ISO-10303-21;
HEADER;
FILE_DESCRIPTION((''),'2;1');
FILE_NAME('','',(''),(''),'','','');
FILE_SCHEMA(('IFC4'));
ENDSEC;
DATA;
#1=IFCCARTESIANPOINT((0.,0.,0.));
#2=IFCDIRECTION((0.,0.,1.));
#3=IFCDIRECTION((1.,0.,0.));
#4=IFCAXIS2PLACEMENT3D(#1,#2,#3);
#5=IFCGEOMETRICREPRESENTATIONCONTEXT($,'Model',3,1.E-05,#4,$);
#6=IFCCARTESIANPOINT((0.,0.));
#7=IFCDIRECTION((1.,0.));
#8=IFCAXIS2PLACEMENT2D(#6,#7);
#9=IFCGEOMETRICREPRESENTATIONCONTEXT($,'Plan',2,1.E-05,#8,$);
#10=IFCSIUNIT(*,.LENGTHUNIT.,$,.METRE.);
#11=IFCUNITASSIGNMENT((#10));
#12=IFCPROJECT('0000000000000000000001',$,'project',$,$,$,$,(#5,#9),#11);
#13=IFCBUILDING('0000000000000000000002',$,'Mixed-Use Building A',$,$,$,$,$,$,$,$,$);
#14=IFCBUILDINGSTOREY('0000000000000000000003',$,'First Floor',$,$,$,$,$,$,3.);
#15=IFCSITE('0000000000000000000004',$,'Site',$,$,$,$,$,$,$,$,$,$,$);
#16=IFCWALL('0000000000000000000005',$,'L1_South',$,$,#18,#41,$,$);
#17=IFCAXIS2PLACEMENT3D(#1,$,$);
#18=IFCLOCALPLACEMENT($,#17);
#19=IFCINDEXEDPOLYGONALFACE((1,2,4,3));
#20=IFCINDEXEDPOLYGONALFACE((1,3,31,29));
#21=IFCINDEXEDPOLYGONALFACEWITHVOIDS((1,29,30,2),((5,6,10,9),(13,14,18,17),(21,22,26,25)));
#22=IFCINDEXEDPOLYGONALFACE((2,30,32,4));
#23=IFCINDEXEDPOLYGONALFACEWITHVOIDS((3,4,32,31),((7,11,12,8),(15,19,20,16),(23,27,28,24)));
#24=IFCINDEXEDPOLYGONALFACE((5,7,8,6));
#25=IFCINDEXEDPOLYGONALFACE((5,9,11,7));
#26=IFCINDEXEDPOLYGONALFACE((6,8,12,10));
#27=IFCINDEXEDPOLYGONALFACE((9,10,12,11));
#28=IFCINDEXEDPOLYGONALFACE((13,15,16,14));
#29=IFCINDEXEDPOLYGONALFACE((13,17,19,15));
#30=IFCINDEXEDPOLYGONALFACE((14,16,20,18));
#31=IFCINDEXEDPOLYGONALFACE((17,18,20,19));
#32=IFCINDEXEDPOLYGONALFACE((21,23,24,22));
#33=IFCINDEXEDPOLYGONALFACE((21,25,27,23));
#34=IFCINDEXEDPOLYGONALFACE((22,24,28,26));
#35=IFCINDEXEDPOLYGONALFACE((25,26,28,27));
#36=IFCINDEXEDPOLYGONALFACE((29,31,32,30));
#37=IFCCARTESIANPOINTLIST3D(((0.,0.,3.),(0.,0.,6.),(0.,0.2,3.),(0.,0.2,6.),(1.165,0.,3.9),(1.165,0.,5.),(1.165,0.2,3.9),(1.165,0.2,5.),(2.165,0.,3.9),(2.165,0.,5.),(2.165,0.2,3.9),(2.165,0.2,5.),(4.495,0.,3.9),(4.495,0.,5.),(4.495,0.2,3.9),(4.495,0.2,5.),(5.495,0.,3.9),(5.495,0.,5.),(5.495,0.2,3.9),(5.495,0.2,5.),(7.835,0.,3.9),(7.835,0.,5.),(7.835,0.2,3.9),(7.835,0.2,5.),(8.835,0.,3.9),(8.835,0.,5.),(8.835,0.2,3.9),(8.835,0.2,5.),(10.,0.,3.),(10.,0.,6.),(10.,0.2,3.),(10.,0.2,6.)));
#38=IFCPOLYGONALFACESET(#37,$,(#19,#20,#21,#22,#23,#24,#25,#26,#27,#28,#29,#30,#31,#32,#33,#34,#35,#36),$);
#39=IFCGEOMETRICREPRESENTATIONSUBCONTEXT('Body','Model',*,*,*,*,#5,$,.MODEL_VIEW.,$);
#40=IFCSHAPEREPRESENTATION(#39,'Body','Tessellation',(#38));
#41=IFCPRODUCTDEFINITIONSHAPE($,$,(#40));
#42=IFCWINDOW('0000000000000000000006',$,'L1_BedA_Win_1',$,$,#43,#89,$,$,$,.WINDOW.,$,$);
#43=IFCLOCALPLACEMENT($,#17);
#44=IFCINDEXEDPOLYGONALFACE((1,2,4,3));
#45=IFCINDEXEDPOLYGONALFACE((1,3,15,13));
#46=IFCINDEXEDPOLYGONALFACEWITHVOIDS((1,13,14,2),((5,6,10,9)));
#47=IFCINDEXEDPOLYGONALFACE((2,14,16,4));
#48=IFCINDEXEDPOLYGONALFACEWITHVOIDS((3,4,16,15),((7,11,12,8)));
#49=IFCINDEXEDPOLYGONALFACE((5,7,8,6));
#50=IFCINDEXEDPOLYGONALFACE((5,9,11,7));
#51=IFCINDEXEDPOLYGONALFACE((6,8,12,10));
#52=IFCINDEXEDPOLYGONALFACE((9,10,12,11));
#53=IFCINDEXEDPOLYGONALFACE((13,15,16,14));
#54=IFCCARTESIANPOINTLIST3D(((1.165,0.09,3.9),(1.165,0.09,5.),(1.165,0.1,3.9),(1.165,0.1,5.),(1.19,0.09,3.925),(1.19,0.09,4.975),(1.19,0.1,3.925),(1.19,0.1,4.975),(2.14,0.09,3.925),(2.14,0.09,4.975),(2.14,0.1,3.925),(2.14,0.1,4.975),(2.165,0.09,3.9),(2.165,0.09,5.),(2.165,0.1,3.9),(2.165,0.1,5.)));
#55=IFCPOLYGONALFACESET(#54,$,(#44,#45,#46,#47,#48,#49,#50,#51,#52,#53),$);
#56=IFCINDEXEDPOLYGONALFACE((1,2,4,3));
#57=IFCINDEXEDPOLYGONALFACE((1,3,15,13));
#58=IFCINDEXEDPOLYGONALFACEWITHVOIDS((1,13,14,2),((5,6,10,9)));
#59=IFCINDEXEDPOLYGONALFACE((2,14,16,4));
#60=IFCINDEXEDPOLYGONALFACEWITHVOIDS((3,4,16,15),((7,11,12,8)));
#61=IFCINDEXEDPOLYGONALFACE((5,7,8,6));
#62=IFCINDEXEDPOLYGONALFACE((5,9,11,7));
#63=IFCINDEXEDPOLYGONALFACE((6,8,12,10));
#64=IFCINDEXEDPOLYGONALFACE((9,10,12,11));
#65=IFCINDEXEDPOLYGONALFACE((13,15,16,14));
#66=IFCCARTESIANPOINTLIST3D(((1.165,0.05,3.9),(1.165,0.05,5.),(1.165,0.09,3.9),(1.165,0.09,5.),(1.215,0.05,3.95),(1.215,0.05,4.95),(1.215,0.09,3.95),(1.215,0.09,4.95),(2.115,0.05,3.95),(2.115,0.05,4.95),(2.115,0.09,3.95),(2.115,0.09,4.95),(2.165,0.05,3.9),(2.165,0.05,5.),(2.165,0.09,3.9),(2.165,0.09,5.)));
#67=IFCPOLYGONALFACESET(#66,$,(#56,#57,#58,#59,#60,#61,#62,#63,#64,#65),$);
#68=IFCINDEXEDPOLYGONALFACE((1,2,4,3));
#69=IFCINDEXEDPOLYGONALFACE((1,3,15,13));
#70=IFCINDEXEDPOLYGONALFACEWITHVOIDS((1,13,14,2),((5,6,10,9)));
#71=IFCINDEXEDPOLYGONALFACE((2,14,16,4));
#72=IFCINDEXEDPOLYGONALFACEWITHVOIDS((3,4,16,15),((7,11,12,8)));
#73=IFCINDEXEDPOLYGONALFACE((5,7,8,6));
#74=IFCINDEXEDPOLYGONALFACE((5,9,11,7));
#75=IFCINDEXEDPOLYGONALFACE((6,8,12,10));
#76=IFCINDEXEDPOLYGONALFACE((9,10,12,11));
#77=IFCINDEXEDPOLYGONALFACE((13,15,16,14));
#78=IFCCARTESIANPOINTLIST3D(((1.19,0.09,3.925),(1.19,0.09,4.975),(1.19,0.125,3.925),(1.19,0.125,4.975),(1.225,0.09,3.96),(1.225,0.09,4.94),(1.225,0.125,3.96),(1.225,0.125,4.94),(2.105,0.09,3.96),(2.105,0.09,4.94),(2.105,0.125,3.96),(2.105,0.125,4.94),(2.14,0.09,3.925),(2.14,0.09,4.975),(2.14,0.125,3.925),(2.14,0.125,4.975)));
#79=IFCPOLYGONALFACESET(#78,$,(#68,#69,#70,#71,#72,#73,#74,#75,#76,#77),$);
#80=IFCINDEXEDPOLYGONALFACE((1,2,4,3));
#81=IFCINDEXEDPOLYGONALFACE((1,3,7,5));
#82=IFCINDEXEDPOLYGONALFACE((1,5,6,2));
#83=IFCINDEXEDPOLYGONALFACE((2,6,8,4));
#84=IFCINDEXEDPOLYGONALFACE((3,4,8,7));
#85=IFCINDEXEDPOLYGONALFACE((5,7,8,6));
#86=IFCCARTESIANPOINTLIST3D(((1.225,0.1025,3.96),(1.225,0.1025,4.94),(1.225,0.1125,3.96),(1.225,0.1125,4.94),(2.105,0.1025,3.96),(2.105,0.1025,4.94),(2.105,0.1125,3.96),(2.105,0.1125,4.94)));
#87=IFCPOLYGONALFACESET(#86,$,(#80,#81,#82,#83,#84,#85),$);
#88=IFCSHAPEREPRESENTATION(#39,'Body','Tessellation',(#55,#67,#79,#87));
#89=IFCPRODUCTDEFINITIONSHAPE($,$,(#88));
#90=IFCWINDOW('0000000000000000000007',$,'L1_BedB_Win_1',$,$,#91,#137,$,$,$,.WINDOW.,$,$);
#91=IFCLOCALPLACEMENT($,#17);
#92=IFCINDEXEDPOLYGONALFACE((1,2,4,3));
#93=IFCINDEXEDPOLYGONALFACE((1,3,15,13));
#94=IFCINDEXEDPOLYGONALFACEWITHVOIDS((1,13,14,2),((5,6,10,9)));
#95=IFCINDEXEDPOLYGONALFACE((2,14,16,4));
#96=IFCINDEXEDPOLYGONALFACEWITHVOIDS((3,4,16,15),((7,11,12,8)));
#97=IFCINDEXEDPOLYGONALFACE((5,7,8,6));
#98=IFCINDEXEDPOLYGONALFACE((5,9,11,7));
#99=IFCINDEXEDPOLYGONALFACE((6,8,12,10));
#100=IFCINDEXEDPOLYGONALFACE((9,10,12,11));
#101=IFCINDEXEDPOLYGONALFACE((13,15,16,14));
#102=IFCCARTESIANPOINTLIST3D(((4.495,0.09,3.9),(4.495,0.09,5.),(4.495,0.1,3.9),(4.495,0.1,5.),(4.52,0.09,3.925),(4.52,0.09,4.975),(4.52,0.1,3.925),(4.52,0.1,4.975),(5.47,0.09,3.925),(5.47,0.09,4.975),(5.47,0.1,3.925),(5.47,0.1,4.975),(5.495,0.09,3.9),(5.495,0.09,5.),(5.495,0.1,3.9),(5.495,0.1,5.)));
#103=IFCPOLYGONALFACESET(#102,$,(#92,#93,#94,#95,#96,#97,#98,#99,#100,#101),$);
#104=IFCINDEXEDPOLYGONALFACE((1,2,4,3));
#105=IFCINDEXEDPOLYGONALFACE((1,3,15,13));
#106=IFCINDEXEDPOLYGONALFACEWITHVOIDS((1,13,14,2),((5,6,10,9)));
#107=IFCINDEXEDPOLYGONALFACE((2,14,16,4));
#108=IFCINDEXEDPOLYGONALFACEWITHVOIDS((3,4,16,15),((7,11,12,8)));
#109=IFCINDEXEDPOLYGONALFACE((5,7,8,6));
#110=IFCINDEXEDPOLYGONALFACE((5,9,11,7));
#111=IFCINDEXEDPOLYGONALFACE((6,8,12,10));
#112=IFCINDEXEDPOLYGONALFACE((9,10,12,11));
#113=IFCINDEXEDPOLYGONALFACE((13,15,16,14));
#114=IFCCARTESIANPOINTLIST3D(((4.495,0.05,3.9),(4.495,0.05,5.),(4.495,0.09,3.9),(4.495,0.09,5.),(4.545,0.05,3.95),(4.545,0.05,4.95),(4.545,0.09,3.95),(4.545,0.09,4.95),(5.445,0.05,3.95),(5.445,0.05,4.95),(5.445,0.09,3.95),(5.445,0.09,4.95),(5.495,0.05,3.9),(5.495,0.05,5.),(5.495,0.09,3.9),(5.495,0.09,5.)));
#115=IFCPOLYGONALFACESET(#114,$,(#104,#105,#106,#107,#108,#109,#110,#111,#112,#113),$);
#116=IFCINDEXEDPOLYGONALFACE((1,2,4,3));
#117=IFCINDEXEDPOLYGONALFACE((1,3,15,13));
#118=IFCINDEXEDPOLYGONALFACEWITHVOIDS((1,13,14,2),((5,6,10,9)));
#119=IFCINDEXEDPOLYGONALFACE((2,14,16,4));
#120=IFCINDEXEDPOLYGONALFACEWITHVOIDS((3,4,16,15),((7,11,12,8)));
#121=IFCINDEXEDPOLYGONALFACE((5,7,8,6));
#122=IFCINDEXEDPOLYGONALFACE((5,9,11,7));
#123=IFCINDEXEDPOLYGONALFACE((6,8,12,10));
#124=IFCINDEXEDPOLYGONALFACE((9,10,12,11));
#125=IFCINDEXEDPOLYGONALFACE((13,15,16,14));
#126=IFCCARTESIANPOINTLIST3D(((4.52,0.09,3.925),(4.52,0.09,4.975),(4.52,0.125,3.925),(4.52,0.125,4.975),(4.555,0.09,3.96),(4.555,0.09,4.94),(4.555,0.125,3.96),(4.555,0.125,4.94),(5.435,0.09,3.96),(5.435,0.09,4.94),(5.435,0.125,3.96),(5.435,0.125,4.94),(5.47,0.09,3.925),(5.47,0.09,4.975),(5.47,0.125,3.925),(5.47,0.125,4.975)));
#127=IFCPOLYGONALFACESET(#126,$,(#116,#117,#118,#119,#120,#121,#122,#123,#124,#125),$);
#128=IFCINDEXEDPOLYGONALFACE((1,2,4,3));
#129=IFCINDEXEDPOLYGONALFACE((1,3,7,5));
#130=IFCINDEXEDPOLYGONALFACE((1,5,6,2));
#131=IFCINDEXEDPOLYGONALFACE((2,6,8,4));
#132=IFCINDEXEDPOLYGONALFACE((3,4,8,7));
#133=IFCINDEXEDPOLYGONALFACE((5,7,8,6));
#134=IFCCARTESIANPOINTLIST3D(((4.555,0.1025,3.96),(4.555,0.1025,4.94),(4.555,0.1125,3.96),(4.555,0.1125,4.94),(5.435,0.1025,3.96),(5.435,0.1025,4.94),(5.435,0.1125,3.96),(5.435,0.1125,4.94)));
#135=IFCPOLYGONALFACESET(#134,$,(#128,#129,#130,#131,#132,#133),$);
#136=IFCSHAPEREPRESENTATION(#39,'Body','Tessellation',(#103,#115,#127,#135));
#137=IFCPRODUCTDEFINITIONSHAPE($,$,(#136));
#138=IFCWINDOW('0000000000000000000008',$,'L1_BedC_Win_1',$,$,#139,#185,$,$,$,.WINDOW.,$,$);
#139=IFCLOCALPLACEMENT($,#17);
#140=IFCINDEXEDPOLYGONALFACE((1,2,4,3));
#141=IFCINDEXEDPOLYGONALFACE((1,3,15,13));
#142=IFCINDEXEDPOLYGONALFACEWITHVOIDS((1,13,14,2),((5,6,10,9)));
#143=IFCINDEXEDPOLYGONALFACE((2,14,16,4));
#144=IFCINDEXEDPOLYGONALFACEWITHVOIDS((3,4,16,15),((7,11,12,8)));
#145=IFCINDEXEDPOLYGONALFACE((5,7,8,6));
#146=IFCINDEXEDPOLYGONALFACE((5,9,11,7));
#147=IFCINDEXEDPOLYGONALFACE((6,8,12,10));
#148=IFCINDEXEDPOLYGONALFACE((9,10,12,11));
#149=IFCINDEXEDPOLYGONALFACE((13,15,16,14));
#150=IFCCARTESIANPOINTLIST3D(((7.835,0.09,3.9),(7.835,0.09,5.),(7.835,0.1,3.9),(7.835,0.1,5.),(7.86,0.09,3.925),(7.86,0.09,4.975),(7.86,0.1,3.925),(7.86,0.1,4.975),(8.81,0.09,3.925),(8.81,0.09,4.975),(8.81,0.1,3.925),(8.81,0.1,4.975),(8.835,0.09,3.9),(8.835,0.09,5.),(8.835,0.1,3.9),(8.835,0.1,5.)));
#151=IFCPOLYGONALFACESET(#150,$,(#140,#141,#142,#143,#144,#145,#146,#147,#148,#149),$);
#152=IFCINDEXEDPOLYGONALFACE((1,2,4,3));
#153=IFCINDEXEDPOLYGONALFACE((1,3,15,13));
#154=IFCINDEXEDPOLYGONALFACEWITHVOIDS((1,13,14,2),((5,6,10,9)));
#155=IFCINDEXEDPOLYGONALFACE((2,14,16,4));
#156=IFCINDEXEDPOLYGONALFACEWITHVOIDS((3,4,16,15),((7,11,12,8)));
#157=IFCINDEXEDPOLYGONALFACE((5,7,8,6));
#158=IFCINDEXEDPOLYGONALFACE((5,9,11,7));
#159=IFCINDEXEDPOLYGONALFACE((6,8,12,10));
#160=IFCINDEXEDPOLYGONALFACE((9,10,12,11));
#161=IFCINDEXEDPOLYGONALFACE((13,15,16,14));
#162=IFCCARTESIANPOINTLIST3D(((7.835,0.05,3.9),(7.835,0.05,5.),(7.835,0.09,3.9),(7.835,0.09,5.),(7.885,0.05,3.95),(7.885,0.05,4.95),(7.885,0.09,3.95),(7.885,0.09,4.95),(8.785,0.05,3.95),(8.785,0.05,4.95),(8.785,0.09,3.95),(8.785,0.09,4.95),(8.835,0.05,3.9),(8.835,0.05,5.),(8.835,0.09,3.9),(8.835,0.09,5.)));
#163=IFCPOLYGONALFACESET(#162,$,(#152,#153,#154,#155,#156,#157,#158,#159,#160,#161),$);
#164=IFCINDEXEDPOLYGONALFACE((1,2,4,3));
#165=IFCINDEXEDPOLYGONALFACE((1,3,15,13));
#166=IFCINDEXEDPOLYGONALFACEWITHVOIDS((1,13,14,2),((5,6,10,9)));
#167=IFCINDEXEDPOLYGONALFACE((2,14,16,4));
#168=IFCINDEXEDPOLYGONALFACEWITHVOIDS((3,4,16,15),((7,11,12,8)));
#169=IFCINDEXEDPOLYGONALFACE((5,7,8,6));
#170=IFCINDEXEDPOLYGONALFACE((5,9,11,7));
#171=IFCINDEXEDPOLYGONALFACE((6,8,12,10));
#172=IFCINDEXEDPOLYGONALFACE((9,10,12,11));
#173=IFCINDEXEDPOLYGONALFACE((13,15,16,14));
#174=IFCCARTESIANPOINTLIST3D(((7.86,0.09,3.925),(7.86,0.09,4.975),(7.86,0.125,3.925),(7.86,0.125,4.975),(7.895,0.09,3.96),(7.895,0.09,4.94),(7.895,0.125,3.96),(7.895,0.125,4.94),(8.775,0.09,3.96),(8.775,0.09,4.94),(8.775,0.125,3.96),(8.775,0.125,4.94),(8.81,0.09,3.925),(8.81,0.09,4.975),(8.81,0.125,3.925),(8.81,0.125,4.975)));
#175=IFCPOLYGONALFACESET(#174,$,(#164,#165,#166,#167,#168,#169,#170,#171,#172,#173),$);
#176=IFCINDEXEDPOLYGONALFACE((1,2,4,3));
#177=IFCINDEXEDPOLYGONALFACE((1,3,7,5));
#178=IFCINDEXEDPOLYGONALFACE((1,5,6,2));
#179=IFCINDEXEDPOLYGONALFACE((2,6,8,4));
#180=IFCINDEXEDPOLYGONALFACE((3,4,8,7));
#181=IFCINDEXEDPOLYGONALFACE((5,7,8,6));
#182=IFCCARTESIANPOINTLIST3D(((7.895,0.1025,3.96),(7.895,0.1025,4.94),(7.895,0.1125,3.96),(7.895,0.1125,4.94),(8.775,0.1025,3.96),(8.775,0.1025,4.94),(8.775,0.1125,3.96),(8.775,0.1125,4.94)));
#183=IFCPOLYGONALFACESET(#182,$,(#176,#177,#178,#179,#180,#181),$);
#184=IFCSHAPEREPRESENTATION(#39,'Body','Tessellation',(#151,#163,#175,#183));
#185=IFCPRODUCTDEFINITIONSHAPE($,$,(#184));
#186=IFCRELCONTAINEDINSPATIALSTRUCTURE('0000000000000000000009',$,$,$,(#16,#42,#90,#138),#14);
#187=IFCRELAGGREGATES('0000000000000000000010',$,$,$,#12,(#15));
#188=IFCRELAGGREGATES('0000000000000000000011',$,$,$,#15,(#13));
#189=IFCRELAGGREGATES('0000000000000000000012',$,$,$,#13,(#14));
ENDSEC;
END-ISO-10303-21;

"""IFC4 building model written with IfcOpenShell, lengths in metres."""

from ifc_helpers import new_model, si_unit, frame, origin_with_axes, origin_2d_with_axis, place, context, subcontext, project, spatial, line, indexed_curve, outline, extrude, element, fill, save


model = new_model("IFC4")

# Units and contexts
model_context = context("Model", 3, precision=1e-05, world=origin_with_axes())
plan_context = context("Plan", 2, precision=1e-05, world=origin_2d_with_axis())
body_context = subcontext(model_context, "Body", "Model", "MODEL_VIEW")
ifc_project = project(units=[si_unit("LENGTHUNIT", "METRE")], contexts=[model_context, plan_context])

# Site, building, storey
site = spatial("IfcSite", under=ifc_project, Name="Site")
building = spatial("IfcBuilding", under=site, Name="Mixed-Use Building A")
storey = spatial("IfcBuildingStorey", under=building, Name="First Floor", Elevation=3.0)

# Wall, openings, windows
wall_1_placement = place(None, frame((0.0, 0.0, 3.0), z_axis=(0.0, 0.0, 1.0), x_axis=(1.0, 0.0, 0.0)))
wall_1 = element("IfcWall", 1, at=wall_1_placement, inside=storey, Name="L1_South", context=body_context, shape_type="SweptSolid", body=[
    extrude(outline(indexed_curve([(0.0, 0.0), (0.0, 0.2), (10.0, 0.2), (10.0, 0.0), (0.0, 0.0)], self_intersect=False)), origin_with_axes(), (0.0, 0.0, 1.0), 3.0),
])
opening_1_placement = place(wall_1_placement, frame((1.165, 0.0, 0.9), z_axis=(0.0, 0.0, 1.0), x_axis=(1.0, 0.0, 0.0)))
opening_1 = element("IfcOpeningElement", 2, at=opening_1_placement, inside=storey, cuts=wall_1, PredefinedType="OPENING", context=body_context, shape_type="SweptSolid", body=[
    extrude(outline(indexed_curve([(0.0, 0.0), (0.0, 0.3), (1.0, 0.3), (1.0, 0.0), (0.0, 0.0)], self_intersect=False)), origin_with_axes(), (0.0, 0.0, 1.0), 1.1),
])
opening_2_placement = place(wall_1_placement, frame((4.495, 0.0, 0.9), z_axis=(0.0, 0.0, 1.0), x_axis=(1.0, 0.0, 0.0)))
opening_2 = element("IfcOpeningElement", 3, at=opening_2_placement, inside=storey, cuts=wall_1, PredefinedType="OPENING", context=body_context, shape_type="SweptSolid", body=[
    extrude(outline(indexed_curve([(0.0, 0.0), (0.0, 0.3), (1.0, 0.3), (1.0, 0.0), (0.0, 0.0)], self_intersect=False)), origin_with_axes(), (0.0, 0.0, 1.0), 1.1),
])
opening_3_placement = place(wall_1_placement, frame((7.835, 0.0, 0.9), z_axis=(0.0, 0.0, 1.0), x_axis=(1.0, 0.0, 0.0)))
opening_3 = element("IfcOpeningElement", 4, at=opening_3_placement, inside=storey, cuts=wall_1, PredefinedType="OPENING", context=body_context, shape_type="SweptSolid", body=[
    extrude(outline(indexed_curve([(0.0, 0.0), (0.0, 0.3), (1.0, 0.3), (1.0, 0.0), (0.0, 0.0)], self_intersect=False)), origin_with_axes(), (0.0, 0.0, 1.0), 1.1),
])
window_1_placement = place(None, frame((1.165, 0.0, 3.9), z_axis=(0.0, 0.0, 1.0), x_axis=(1.0, 0.0, 0.0)))
window_1 = element("IfcWindow", 5, at=window_1_placement, inside=storey, Name="L1_BedA_Win_1", PredefinedType="WINDOW", context=body_context, shape_type="SweptSolid", body=[
    extrude(outline(indexed_curve([(0.0, 0.0), (1.0, 0.0), (1.0, 1.1), (0.0, 1.1)], segments=[line(1, 2, 3, 4, 1)]), holes=[indexed_curve([(0.025, 0.025), (0.975, 0.025), (0.975, 1.075), (0.025, 1.075)], segments=[line(1, 2, 3, 4, 1)])]), frame((0.0, 0.09, 0.0), z_axis=(0.0, -1.0, 0.0), x_axis=(1.0, 0.0, 0.0)), (0.0, 0.0, -1.0), 0.01),
    extrude(outline(indexed_curve([(0.0, 0.0), (1.0, 0.0), (1.0, 1.1), (0.0, 1.1)], segments=[line(1, 2, 3, 4, 1)]), holes=[indexed_curve([(0.05, 0.05), (0.95, 0.05), (0.95, 1.05), (0.05, 1.05)], segments=[line(1, 2, 3, 4, 1)])]), frame((0.0, 0.05, 0.0), z_axis=(0.0, -1.0, 0.0), x_axis=(1.0, 0.0, 0.0)), (0.0, 0.0, -1.0), 0.04),
    extrude(outline(indexed_curve([(0.0, 0.0), (0.95, 0.0), (0.95, 1.05), (0.0, 1.05)], segments=[line(1, 2, 3, 4, 1)]), holes=[indexed_curve([(0.035, 0.035), (0.915, 0.035), (0.915, 1.015), (0.035, 1.015)], segments=[line(1, 2, 3, 4, 1)])]), frame((0.025, 0.09, 0.025), z_axis=(0.0, -1.0, 0.0), x_axis=(1.0, 0.0, 0.0)), (0.0, 0.0, -1.0), 0.035),
    extrude(outline(indexed_curve([(0.035, 0.035), (0.915, 0.035), (0.915, 1.015), (0.035, 1.015)], segments=[line(1, 2, 3, 4, 1)])), frame((0.025, 0.1025, 0.025), z_axis=(0.0, -1.0, 0.0), x_axis=(1.0, 0.0, 0.0)), (0.0, 0.0, -1.0), 0.01),
])
fill(opening_1, window_1)
window_2_placement = place(None, frame((4.495, 0.0, 3.9), z_axis=(0.0, 0.0, 1.0), x_axis=(1.0, 0.0, 0.0)))
window_2 = element("IfcWindow", 6, at=window_2_placement, inside=storey, Name="L1_BedB_Win_1", PredefinedType="WINDOW", context=body_context, shape_type="SweptSolid", body=[
    extrude(outline(indexed_curve([(0.0, 0.0), (1.0, 0.0), (1.0, 1.1), (0.0, 1.1)], segments=[line(1, 2, 3, 4, 1)]), holes=[indexed_curve([(0.025, 0.025), (0.975, 0.025), (0.975, 1.075), (0.025, 1.075)], segments=[line(1, 2, 3, 4, 1)])]), frame((0.0, 0.09, 0.0), z_axis=(0.0, -1.0, 0.0), x_axis=(1.0, 0.0, 0.0)), (0.0, 0.0, -1.0), 0.01),
    extrude(outline(indexed_curve([(0.0, 0.0), (1.0, 0.0), (1.0, 1.1), (0.0, 1.1)], segments=[line(1, 2, 3, 4, 1)]), holes=[indexed_curve([(0.05, 0.05), (0.95, 0.05), (0.95, 1.05), (0.05, 1.05)], segments=[line(1, 2, 3, 4, 1)])]), frame((0.0, 0.05, 0.0), z_axis=(0.0, -1.0, 0.0), x_axis=(1.0, 0.0, 0.0)), (0.0, 0.0, -1.0), 0.04),
    extrude(outline(indexed_curve([(0.0, 0.0), (0.95, 0.0), (0.95, 1.05), (0.0, 1.05)], segments=[line(1, 2, 3, 4, 1)]), holes=[indexed_curve([(0.035, 0.035), (0.915, 0.035), (0.915, 1.015), (0.035, 1.015)], segments=[line(1, 2, 3, 4, 1)])]), frame((0.025, 0.09, 0.025), z_axis=(0.0, -1.0, 0.0), x_axis=(1.0, 0.0, 0.0)), (0.0, 0.0, -1.0), 0.035),
    extrude(outline(indexed_curve([(0.035, 0.035), (0.915, 0.035), (0.915, 1.015), (0.035, 1.015)], segments=[line(1, 2, 3, 4, 1)])), frame((0.025, 0.1025, 0.025), z_axis=(0.0, -1.0, 0.0), x_axis=(1.0, 0.0, 0.0)), (0.0, 0.0, -1.0), 0.01),
])
fill(opening_2, window_2)
window_3_placement = place(None, frame((7.835, 0.0, 3.9), z_axis=(0.0, 0.0, 1.0), x_axis=(1.0, 0.0, 0.0)))
window_3 = element("IfcWindow", 7, at=window_3_placement, inside=storey, Name="L1_BedC_Win_1", PredefinedType="WINDOW", context=body_context, shape_type="SweptSolid", body=[
    extrude(outline(indexed_curve([(0.0, 0.0), (1.0, 0.0), (1.0, 1.1), (0.0, 1.1)], segments=[line(1, 2, 3, 4, 1)]), holes=[indexed_curve([(0.025, 0.025), (0.975, 0.025), (0.975, 1.075), (0.025, 1.075)], segments=[line(1, 2, 3, 4, 1)])]), frame((0.0, 0.09, 0.0), z_axis=(0.0, -1.0, 0.0), x_axis=(1.0, 0.0, 0.0)), (0.0, 0.0, -1.0), 0.01),
    extrude(outline(indexed_curve([(0.0, 0.0), (1.0, 0.0), (1.0, 1.1), (0.0, 1.1)], segments=[line(1, 2, 3, 4, 1)]), holes=[indexed_curve([(0.05, 0.05), (0.95, 0.05), (0.95, 1.05), (0.05, 1.05)], segments=[line(1, 2, 3, 4, 1)])]), frame((0.0, 0.05, 0.0), z_axis=(0.0, -1.0, 0.0), x_axis=(1.0, 0.0, 0.0)), (0.0, 0.0, -1.0), 0.04),
    extrude(outline(indexed_curve([(0.0, 0.0), (0.95, 0.0), (0.95, 1.05), (0.0, 1.05)], segments=[line(1, 2, 3, 4, 1)]), holes=[indexed_curve([(0.035, 0.035), (0.915, 0.035), (0.915, 1.015), (0.035, 1.015)], segments=[line(1, 2, 3, 4, 1)])]), frame((0.025, 0.09, 0.025), z_axis=(0.0, -1.0, 0.0), x_axis=(1.0, 0.0, 0.0)), (0.0, 0.0, -1.0), 0.035),
    extrude(outline(indexed_curve([(0.035, 0.035), (0.915, 0.035), (0.915, 1.015), (0.035, 1.015)], segments=[line(1, 2, 3, 4, 1)])), frame((0.025, 0.1025, 0.025), z_axis=(0.0, -1.0, 0.0), x_axis=(1.0, 0.0, 0.0)), (0.0, 0.0, -1.0), 0.01),
])
fill(opening_3, window_3)

save(model, "model.ifc")
